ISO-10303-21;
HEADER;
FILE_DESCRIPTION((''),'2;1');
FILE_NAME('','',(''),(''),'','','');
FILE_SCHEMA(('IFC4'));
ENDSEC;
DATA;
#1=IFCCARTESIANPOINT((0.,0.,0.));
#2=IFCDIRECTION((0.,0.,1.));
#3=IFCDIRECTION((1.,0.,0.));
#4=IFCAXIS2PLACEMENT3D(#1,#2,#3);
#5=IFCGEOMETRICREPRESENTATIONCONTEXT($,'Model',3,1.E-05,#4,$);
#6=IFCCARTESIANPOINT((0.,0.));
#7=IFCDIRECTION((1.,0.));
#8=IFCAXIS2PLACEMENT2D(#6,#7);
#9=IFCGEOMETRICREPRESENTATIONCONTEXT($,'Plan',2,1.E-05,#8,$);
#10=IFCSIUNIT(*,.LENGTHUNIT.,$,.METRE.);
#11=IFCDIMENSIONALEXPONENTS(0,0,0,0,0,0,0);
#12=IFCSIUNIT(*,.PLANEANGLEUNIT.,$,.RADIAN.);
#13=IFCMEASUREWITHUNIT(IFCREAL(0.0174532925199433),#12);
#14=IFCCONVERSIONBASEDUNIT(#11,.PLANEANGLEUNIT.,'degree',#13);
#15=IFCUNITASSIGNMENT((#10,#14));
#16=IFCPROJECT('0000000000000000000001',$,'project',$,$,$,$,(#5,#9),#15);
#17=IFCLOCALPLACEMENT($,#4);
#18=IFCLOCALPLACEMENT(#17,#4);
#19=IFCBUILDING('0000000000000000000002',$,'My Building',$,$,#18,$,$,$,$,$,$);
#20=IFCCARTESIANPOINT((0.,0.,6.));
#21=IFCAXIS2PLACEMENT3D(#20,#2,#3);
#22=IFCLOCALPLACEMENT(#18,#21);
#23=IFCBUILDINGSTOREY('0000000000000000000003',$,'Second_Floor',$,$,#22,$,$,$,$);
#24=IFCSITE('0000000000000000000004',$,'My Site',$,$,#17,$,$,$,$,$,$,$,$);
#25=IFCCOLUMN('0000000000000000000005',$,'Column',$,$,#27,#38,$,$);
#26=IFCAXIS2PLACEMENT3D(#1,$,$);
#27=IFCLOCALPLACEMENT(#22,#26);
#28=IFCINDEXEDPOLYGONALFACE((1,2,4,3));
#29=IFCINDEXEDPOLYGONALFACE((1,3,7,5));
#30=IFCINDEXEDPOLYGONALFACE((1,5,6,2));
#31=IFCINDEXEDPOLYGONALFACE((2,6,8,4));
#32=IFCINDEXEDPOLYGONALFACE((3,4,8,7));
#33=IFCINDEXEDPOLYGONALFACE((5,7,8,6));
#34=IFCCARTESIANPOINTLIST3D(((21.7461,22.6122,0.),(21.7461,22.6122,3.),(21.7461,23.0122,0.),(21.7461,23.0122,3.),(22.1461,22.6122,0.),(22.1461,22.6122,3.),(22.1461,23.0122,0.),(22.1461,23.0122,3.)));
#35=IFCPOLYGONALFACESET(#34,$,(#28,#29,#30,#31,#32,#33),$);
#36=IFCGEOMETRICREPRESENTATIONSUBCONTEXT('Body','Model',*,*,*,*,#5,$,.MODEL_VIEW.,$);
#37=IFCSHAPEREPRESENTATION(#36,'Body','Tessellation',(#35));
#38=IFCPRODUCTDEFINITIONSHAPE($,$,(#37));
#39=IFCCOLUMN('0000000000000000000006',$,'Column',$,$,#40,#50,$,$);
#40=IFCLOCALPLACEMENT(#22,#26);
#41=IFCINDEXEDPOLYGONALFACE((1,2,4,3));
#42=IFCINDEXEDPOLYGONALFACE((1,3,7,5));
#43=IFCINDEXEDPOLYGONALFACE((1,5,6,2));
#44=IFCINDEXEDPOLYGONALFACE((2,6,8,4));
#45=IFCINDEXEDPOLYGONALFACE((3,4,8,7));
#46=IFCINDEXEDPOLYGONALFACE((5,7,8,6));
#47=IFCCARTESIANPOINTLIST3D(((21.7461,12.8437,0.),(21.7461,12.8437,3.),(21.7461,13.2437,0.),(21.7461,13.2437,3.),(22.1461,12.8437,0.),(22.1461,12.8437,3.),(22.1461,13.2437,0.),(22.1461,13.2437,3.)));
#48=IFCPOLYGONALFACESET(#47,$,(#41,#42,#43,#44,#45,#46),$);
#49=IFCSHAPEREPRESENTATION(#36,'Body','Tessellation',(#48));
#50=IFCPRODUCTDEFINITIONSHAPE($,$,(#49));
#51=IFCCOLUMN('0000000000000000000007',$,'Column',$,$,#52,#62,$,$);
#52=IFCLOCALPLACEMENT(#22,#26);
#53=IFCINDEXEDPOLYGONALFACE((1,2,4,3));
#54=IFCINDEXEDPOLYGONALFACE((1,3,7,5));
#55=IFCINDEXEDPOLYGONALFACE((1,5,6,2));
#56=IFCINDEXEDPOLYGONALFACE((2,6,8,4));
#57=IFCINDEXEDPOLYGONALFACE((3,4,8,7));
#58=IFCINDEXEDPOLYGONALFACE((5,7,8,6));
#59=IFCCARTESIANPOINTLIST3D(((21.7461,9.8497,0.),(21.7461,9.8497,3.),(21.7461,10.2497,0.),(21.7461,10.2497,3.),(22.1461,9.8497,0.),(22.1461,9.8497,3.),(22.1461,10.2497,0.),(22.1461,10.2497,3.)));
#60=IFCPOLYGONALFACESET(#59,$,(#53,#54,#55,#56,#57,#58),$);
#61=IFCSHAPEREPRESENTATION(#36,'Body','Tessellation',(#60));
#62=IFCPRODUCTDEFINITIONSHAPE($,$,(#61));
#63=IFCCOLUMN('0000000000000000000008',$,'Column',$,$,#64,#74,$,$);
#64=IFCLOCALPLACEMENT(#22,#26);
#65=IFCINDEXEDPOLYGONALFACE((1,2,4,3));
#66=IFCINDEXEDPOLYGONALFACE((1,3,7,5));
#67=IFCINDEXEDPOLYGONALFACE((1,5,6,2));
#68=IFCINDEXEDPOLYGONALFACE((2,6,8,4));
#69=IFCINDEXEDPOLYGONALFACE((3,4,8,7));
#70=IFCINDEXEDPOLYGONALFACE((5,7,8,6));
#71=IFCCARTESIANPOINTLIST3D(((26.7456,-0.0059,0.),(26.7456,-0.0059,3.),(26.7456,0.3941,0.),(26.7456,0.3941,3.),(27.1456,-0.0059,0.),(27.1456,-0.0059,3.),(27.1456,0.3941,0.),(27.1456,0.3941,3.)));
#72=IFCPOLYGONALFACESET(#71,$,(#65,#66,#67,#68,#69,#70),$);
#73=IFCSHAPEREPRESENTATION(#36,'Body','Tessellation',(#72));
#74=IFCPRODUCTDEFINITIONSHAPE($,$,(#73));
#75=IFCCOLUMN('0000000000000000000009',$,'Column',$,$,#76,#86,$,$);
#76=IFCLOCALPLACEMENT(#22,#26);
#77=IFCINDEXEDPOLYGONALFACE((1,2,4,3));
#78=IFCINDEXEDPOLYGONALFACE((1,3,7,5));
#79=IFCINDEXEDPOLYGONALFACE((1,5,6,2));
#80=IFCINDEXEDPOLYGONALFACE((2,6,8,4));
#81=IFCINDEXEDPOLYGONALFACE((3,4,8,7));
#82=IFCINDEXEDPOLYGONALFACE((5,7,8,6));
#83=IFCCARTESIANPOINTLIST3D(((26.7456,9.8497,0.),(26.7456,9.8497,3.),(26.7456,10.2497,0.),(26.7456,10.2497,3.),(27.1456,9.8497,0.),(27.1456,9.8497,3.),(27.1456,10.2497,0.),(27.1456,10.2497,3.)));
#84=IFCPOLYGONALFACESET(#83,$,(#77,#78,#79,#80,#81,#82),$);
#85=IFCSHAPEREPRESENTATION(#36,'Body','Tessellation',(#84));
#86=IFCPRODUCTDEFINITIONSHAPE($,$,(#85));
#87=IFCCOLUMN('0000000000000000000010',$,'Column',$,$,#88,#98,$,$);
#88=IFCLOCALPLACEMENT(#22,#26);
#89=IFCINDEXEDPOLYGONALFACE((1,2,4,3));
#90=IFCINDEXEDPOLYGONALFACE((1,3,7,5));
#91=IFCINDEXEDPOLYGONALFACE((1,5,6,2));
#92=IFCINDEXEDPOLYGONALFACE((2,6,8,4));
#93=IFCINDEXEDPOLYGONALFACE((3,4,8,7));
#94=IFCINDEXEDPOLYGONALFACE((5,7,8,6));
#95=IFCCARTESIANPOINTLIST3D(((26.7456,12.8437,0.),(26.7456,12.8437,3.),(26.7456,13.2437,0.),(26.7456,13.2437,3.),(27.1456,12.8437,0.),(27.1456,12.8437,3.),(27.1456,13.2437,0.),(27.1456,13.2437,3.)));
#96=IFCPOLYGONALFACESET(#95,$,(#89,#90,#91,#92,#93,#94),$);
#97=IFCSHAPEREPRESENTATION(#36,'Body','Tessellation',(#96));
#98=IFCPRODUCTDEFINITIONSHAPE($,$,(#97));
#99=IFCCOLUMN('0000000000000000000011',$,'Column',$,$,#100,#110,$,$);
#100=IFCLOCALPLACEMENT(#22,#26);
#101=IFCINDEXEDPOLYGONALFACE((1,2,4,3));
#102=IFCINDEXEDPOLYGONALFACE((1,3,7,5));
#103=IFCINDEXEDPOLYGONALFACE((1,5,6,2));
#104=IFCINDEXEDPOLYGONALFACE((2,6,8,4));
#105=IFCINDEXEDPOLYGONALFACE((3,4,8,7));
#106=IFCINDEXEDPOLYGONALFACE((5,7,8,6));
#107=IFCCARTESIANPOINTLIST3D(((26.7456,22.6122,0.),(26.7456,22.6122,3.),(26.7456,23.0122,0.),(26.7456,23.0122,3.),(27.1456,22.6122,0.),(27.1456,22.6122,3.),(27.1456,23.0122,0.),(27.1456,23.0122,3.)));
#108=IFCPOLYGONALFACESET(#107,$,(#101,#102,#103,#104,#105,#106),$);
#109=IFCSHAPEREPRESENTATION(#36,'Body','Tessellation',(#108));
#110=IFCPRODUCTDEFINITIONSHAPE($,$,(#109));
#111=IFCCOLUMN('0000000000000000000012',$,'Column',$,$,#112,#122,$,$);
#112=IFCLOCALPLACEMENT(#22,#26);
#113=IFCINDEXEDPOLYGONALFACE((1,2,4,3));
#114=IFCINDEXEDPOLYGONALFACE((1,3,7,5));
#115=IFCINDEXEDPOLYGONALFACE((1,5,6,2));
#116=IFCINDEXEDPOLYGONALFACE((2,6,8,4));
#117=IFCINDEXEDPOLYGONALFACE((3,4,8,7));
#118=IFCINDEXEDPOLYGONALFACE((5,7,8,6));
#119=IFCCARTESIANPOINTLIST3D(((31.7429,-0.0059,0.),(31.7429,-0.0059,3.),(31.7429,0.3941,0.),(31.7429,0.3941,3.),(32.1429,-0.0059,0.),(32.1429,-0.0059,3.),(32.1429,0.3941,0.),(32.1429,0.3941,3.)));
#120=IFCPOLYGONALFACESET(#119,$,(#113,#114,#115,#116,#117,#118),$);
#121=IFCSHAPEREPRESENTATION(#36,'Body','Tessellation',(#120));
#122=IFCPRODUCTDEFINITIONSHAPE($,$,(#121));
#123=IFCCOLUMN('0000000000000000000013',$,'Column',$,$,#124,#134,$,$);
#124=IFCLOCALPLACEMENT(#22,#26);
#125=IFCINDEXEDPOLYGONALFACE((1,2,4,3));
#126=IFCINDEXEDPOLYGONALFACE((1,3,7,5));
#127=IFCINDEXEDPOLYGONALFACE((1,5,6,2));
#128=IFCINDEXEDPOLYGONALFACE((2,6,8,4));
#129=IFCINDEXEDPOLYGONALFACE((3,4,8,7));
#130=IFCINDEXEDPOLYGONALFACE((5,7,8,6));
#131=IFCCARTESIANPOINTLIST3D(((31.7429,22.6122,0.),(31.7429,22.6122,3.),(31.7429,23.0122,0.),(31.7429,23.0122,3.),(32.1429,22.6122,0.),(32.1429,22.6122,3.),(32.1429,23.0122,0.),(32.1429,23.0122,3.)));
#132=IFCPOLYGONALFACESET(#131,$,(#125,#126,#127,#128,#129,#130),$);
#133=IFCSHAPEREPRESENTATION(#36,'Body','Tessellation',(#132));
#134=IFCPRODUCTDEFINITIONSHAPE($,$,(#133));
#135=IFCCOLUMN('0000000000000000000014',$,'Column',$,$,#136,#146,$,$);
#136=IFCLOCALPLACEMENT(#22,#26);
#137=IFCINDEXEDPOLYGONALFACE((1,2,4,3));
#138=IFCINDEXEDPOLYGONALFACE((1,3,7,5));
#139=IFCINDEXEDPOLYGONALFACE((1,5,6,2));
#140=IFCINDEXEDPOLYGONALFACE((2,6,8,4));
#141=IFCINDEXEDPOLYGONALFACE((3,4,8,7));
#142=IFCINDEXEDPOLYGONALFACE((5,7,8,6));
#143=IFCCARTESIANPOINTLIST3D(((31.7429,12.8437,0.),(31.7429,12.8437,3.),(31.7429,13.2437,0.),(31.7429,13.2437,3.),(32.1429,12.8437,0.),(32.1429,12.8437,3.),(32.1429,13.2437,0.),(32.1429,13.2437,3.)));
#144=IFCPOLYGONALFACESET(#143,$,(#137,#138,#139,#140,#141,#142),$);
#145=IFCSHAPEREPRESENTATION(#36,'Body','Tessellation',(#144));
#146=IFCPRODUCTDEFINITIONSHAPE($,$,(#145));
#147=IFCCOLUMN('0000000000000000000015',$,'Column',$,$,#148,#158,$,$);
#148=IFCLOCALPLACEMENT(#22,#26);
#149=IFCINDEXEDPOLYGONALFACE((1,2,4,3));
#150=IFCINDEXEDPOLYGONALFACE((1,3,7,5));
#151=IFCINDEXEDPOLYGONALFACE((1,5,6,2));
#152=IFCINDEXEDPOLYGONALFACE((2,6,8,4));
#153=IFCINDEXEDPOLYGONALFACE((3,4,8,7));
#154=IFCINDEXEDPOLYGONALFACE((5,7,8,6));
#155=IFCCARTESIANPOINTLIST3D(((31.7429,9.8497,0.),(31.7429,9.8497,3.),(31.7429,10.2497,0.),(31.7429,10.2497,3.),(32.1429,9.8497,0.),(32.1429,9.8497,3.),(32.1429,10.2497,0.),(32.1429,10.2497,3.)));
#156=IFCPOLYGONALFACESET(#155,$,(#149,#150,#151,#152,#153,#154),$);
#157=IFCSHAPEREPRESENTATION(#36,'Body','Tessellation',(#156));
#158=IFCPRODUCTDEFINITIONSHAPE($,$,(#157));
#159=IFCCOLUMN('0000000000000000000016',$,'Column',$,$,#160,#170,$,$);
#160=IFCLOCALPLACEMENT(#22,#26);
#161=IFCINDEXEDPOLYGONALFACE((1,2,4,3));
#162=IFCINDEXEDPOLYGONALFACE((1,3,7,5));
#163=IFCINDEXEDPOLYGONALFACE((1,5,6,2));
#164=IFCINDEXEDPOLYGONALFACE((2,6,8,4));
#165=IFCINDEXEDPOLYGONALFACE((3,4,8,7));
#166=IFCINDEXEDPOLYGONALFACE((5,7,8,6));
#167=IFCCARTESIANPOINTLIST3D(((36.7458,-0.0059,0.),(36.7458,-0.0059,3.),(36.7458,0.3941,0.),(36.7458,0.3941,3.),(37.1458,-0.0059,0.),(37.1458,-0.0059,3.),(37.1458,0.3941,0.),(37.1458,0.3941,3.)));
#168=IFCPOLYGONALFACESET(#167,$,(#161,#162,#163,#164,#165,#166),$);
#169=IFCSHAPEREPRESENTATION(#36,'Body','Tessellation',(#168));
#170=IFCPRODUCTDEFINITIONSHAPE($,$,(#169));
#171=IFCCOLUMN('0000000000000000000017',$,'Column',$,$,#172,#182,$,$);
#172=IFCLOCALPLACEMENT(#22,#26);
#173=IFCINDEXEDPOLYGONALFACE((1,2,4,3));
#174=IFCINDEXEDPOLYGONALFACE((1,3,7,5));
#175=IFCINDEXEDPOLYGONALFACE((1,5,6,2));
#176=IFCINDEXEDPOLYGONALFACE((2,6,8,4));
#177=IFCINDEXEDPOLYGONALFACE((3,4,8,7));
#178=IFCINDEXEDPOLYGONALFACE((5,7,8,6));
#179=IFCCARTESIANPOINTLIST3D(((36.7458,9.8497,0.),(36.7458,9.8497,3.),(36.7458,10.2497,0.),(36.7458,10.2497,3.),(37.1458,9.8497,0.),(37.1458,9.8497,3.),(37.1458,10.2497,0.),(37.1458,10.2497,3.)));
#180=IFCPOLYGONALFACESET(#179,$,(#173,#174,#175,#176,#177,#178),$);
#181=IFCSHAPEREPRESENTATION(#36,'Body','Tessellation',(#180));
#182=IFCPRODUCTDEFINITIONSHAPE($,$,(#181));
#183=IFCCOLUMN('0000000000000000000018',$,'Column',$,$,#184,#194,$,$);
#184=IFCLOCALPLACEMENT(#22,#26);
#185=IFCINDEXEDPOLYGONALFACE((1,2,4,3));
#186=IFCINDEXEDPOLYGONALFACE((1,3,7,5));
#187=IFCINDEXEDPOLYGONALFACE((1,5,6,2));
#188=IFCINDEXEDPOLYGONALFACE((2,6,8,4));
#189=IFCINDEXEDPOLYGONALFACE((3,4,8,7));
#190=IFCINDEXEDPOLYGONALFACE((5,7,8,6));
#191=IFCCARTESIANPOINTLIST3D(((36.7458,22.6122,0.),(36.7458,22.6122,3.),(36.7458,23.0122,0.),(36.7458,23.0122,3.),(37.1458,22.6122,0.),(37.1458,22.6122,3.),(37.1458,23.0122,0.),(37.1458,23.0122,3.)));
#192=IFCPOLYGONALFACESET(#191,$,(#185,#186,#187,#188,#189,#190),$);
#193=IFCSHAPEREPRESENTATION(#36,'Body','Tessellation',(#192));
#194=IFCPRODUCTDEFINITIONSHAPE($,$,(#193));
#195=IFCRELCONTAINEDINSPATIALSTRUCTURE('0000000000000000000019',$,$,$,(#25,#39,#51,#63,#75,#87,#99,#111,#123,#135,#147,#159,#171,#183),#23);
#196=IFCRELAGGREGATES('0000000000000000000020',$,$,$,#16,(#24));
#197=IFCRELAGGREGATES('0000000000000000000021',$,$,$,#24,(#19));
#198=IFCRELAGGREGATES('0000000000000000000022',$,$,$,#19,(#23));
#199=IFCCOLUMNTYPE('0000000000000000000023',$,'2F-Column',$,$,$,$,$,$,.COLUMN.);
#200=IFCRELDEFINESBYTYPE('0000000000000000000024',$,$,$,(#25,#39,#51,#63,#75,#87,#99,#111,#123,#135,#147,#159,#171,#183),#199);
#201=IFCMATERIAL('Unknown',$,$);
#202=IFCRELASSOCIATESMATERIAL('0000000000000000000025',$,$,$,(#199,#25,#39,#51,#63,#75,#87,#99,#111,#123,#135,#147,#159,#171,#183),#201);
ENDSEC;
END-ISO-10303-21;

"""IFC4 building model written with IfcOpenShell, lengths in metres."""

from ifc_helpers import new_model, entity, si_unit, converted_unit, frame, origin_with_axes, origin_2d_with_axis, place, context, subcontext, project, spatial, rectangle, extrude, material, material_profile, profile_set, profile_usage, type_object, element, save


model = new_model("IFC4")

# Units and contexts
model_context = context("Model", 3, precision=1e-05, world=origin_with_axes())
plan_context = context("Plan", 2, precision=1e-05, world=origin_2d_with_axis())
body_context = subcontext(model_context, "Body", "Model", "MODEL_VIEW")
ifc_project = project(units=[si_unit("LENGTHUNIT", "METRE"), converted_unit("PLANEANGLEUNIT", "degree", entity("IfcReal", 0.0174532925199433), si_unit("PLANEANGLEUNIT", "RADIAN"), dimensions=[0, 0, 0, 0, 0, 0, 0])], contexts=[model_context, plan_context])

# Site, building, storey
site_placement = place(None, origin_with_axes())
site = spatial("IfcSite", under=ifc_project, at=site_placement, Name="My Site")
building_placement = place(site_placement, origin_with_axes())
building = spatial("IfcBuilding", under=site, at=building_placement, Name="My Building")
storey_placement = place(building_placement, frame((0.0, 0.0, 6.0), z_axis=(0.0, 0.0, 1.0), x_axis=(1.0, 0.0, 0.0)))
storey = spatial("IfcBuildingStorey", under=building, at=storey_placement, Name="Second_Floor")

# Columns
ifc_material = material(Name="Unknown")
ifc_material_profile_1 = material_profile(ifc_material, rectangle(XDim=0.4, YDim=0.4))
ifc_profile_set_1 = profile_set([ifc_material_profile_1])
ifc_profile_usage_1 = profile_usage(ifc_profile_set_1, cardinal=8)
column_type = type_object("IfcColumnType", Name="2F-Column", PredefinedType="COLUMN", material=ifc_profile_set_1)
column_1_placement = place(storey_placement, frame((21.9461, 23.0122, 0.0), z_axis=(0.0, 0.0, 1.0), x_axis=(1.0, 0.0, 0.0)))
element("IfcColumn", 1, at=column_1_placement, inside=storey, type_object=column_type, material=ifc_profile_usage_1, Name="Column", context=body_context, shape_type="SweptSolid", body=[
    extrude(rectangle(XDim=0.4, YDim=0.4), frame((0.0, -0.2, 0.0), z_axis=(0.0, 0.0, 1.0), x_axis=(1.0, 0.0, 0.0)), (0.0, 0.0, 1.0), 3.0),
])
ifc_profile_usage_2 = profile_usage(ifc_profile_set_1, cardinal=8)
column_2_placement = place(storey_placement, frame((21.9461, 13.2437, 0.0), z_axis=(0.0, 0.0, 1.0), x_axis=(1.0, 0.0, 0.0)))
element("IfcColumn", 2, at=column_2_placement, inside=storey, type_object=column_type, material=ifc_profile_usage_2, Name="Column", context=body_context, shape_type="SweptSolid", body=[
    extrude(rectangle(XDim=0.4, YDim=0.4), frame((0.0, -0.2, 0.0), z_axis=(0.0, 0.0, 1.0), x_axis=(1.0, 0.0, 0.0)), (0.0, 0.0, 1.0), 3.0),
])
ifc_profile_usage_3 = profile_usage(ifc_profile_set_1, cardinal=8)
column_3_placement = place(storey_placement, frame((21.9461, 10.2497, 0.0), z_axis=(0.0, 0.0, 1.0), x_axis=(1.0, 0.0, 0.0)))
element("IfcColumn", 3, at=column_3_placement, inside=storey, type_object=column_type, material=ifc_profile_usage_3, Name="Column", context=body_context, shape_type="SweptSolid", body=[
    extrude(rectangle(XDim=0.4, YDim=0.4), frame((0.0, -0.2, 0.0), z_axis=(0.0, 0.0, 1.0), x_axis=(1.0, 0.0, 0.0)), (0.0, 0.0, 1.0), 3.0),
])
ifc_profile_usage_4 = profile_usage(ifc_profile_set_1, cardinal=8)
column_4_placement = place(storey_placement, frame((26.9456, 0.3941, 0.0), z_axis=(0.0, 0.0, 1.0), x_axis=(1.0, 0.0, 0.0)))
element("IfcColumn", 4, at=column_4_placement, inside=storey, type_object=column_type, material=ifc_profile_usage_4, Name="Column", context=body_context, shape_type="SweptSolid", body=[
    extrude(rectangle(XDim=0.4, YDim=0.4), frame((0.0, -0.2, 0.0), z_axis=(0.0, 0.0, 1.0), x_axis=(1.0, 0.0, 0.0)), (0.0, 0.0, 1.0), 3.0),
])
ifc_profile_usage_5 = profile_usage(ifc_profile_set_1, cardinal=8)
column_5_placement = place(storey_placement, frame((26.9456, 10.2497, 0.0), z_axis=(0.0, 0.0, 1.0), x_axis=(1.0, 0.0, 0.0)))
element("IfcColumn", 5, at=column_5_placement, inside=storey, type_object=column_type, material=ifc_profile_usage_5, Name="Column", context=body_context, shape_type="SweptSolid", body=[
    extrude(rectangle(XDim=0.4, YDim=0.4), frame((0.0, -0.2, 0.0), z_axis=(0.0, 0.0, 1.0), x_axis=(1.0, 0.0, 0.0)), (0.0, 0.0, 1.0), 3.0),
])
ifc_profile_usage_6 = profile_usage(ifc_profile_set_1, cardinal=8)
column_6_placement = place(storey_placement, frame((26.9456, 13.2437, 0.0), z_axis=(0.0, 0.0, 1.0), x_axis=(1.0, 0.0, 0.0)))
element("IfcColumn", 6, at=column_6_placement, inside=storey, type_object=column_type, material=ifc_profile_usage_6, Name="Column", context=body_context, shape_type="SweptSolid", body=[
    extrude(rectangle(XDim=0.4, YDim=0.4), frame((0.0, -0.2, 0.0), z_axis=(0.0, 0.0, 1.0), x_axis=(1.0, 0.0, 0.0)), (0.0, 0.0, 1.0), 3.0),
])
ifc_profile_usage_7 = profile_usage(ifc_profile_set_1, cardinal=8)
column_7_placement = place(storey_placement, frame((26.9456, 23.0122, 0.0), z_axis=(0.0, 0.0, 1.0), x_axis=(1.0, 0.0, 0.0)))
element("IfcColumn", 7, at=column_7_placement, inside=storey, type_object=column_type, material=ifc_profile_usage_7, Name="Column", context=body_context, shape_type="SweptSolid", body=[
    extrude(rectangle(XDim=0.4, YDim=0.4), frame((0.0, -0.2, 0.0), z_axis=(0.0, 0.0, 1.0), x_axis=(1.0, 0.0, 0.0)), (0.0, 0.0, 1.0), 3.0),
])
ifc_profile_usage_8 = profile_usage(ifc_profile_set_1, cardinal=8)
column_8_placement = place(storey_placement, frame((31.9429, 0.3941, 0.0), z_axis=(0.0, 0.0, 1.0), x_axis=(1.0, 0.0, 0.0)))
element("IfcColumn", 8, at=column_8_placement, inside=storey, type_object=column_type, material=ifc_profile_usage_8, Name="Column", context=body_context, shape_type="SweptSolid", body=[
    extrude(rectangle(XDim=0.4, YDim=0.4), frame((0.0, -0.2, 0.0), z_axis=(0.0, 0.0, 1.0), x_axis=(1.0, 0.0, 0.0)), (0.0, 0.0, 1.0), 3.0),
])
ifc_profile_usage_9 = profile_usage(ifc_profile_set_1, cardinal=8)
column_9_placement = place(storey_placement, frame((31.9429, 23.0122, 0.0), z_axis=(0.0, 0.0, 1.0), x_axis=(1.0, 0.0, 0.0)))
element("IfcColumn", 9, at=column_9_placement, inside=storey, type_object=column_type, material=ifc_profile_usage_9, Name="Column", context=body_context, shape_type="SweptSolid", body=[
    extrude(rectangle(XDim=0.4, YDim=0.4), frame((0.0, -0.2, 0.0), z_axis=(0.0, 0.0, 1.0), x_axis=(1.0, 0.0, 0.0)), (0.0, 0.0, 1.0), 3.0),
])
ifc_profile_usage_10 = profile_usage(ifc_profile_set_1, cardinal=8)
column_10_placement = place(storey_placement, frame((31.9429, 13.2437, 0.0), z_axis=(0.0, 0.0, 1.0), x_axis=(1.0, 0.0, 0.0)))
element("IfcColumn", 10, at=column_10_placement, inside=storey, type_object=column_type, material=ifc_profile_usage_10, Name="Column", context=body_context, shape_type="SweptSolid", body=[
    extrude(rectangle(XDim=0.4, YDim=0.4), frame((0.0, -0.2, 0.0), z_axis=(0.0, 0.0, 1.0), x_axis=(1.0, 0.0, 0.0)), (0.0, 0.0, 1.0), 3.0),
])
ifc_profile_usage_11 = profile_usage(ifc_profile_set_1, cardinal=8)
column_11_placement = place(storey_placement, frame((31.9429, 10.2497, 0.0), z_axis=(0.0, 0.0, 1.0), x_axis=(1.0, 0.0, 0.0)))
element("IfcColumn", 11, at=column_11_placement, inside=storey, type_object=column_type, material=ifc_profile_usage_11, Name="Column", context=body_context, shape_type="SweptSolid", body=[
    extrude(rectangle(XDim=0.4, YDim=0.4), frame((0.0, -0.2, 0.0), z_axis=(0.0, 0.0, 1.0), x_axis=(1.0, 0.0, 0.0)), (0.0, 0.0, 1.0), 3.0),
])
ifc_profile_usage_12 = profile_usage(ifc_profile_set_1, cardinal=8)
column_12_placement = place(storey_placement, frame((36.9458, 0.3941, 0.0), z_axis=(0.0, 0.0, 1.0), x_axis=(1.0, 0.0, 0.0)))
element("IfcColumn", 12, at=column_12_placement, inside=storey, type_object=column_type, material=ifc_profile_usage_12, Name="Column", context=body_context, shape_type="SweptSolid", body=[
    extrude(rectangle(XDim=0.4, YDim=0.4), frame((0.0, -0.2, 0.0), z_axis=(0.0, 0.0, 1.0), x_axis=(1.0, 0.0, 0.0)), (0.0, 0.0, 1.0), 3.0),
])
ifc_profile_usage_13 = profile_usage(ifc_profile_set_1, cardinal=8)
column_13_placement = place(storey_placement, frame((36.9458, 10.2497, 0.0), z_axis=(0.0, 0.0, 1.0), x_axis=(1.0, 0.0, 0.0)))
element("IfcColumn", 13, at=column_13_placement, inside=storey, type_object=column_type, material=ifc_profile_usage_13, Name="Column", context=body_context, shape_type="SweptSolid", body=[
    extrude(rectangle(XDim=0.4, YDim=0.4), frame((0.0, -0.2, 0.0), z_axis=(0.0, 0.0, 1.0), x_axis=(1.0, 0.0, 0.0)), (0.0, 0.0, 1.0), 3.0),
])
ifc_profile_usage_14 = profile_usage(ifc_profile_set_1, cardinal=8)
column_14_placement = place(storey_placement, frame((36.9458, 23.0122, 0.0), z_axis=(0.0, 0.0, 1.0), x_axis=(1.0, 0.0, 0.0)))
element("IfcColumn", 14, at=column_14_placement, inside=storey, type_object=column_type, material=ifc_profile_usage_14, Name="Column", context=body_context, shape_type="SweptSolid", body=[
    extrude(rectangle(XDim=0.4, YDim=0.4), frame((0.0, -0.2, 0.0), z_axis=(0.0, 0.0, 1.0), x_axis=(1.0, 0.0, 0.0)), (0.0, 0.0, 1.0), 3.0),
])

save(model, "model.ifc")
